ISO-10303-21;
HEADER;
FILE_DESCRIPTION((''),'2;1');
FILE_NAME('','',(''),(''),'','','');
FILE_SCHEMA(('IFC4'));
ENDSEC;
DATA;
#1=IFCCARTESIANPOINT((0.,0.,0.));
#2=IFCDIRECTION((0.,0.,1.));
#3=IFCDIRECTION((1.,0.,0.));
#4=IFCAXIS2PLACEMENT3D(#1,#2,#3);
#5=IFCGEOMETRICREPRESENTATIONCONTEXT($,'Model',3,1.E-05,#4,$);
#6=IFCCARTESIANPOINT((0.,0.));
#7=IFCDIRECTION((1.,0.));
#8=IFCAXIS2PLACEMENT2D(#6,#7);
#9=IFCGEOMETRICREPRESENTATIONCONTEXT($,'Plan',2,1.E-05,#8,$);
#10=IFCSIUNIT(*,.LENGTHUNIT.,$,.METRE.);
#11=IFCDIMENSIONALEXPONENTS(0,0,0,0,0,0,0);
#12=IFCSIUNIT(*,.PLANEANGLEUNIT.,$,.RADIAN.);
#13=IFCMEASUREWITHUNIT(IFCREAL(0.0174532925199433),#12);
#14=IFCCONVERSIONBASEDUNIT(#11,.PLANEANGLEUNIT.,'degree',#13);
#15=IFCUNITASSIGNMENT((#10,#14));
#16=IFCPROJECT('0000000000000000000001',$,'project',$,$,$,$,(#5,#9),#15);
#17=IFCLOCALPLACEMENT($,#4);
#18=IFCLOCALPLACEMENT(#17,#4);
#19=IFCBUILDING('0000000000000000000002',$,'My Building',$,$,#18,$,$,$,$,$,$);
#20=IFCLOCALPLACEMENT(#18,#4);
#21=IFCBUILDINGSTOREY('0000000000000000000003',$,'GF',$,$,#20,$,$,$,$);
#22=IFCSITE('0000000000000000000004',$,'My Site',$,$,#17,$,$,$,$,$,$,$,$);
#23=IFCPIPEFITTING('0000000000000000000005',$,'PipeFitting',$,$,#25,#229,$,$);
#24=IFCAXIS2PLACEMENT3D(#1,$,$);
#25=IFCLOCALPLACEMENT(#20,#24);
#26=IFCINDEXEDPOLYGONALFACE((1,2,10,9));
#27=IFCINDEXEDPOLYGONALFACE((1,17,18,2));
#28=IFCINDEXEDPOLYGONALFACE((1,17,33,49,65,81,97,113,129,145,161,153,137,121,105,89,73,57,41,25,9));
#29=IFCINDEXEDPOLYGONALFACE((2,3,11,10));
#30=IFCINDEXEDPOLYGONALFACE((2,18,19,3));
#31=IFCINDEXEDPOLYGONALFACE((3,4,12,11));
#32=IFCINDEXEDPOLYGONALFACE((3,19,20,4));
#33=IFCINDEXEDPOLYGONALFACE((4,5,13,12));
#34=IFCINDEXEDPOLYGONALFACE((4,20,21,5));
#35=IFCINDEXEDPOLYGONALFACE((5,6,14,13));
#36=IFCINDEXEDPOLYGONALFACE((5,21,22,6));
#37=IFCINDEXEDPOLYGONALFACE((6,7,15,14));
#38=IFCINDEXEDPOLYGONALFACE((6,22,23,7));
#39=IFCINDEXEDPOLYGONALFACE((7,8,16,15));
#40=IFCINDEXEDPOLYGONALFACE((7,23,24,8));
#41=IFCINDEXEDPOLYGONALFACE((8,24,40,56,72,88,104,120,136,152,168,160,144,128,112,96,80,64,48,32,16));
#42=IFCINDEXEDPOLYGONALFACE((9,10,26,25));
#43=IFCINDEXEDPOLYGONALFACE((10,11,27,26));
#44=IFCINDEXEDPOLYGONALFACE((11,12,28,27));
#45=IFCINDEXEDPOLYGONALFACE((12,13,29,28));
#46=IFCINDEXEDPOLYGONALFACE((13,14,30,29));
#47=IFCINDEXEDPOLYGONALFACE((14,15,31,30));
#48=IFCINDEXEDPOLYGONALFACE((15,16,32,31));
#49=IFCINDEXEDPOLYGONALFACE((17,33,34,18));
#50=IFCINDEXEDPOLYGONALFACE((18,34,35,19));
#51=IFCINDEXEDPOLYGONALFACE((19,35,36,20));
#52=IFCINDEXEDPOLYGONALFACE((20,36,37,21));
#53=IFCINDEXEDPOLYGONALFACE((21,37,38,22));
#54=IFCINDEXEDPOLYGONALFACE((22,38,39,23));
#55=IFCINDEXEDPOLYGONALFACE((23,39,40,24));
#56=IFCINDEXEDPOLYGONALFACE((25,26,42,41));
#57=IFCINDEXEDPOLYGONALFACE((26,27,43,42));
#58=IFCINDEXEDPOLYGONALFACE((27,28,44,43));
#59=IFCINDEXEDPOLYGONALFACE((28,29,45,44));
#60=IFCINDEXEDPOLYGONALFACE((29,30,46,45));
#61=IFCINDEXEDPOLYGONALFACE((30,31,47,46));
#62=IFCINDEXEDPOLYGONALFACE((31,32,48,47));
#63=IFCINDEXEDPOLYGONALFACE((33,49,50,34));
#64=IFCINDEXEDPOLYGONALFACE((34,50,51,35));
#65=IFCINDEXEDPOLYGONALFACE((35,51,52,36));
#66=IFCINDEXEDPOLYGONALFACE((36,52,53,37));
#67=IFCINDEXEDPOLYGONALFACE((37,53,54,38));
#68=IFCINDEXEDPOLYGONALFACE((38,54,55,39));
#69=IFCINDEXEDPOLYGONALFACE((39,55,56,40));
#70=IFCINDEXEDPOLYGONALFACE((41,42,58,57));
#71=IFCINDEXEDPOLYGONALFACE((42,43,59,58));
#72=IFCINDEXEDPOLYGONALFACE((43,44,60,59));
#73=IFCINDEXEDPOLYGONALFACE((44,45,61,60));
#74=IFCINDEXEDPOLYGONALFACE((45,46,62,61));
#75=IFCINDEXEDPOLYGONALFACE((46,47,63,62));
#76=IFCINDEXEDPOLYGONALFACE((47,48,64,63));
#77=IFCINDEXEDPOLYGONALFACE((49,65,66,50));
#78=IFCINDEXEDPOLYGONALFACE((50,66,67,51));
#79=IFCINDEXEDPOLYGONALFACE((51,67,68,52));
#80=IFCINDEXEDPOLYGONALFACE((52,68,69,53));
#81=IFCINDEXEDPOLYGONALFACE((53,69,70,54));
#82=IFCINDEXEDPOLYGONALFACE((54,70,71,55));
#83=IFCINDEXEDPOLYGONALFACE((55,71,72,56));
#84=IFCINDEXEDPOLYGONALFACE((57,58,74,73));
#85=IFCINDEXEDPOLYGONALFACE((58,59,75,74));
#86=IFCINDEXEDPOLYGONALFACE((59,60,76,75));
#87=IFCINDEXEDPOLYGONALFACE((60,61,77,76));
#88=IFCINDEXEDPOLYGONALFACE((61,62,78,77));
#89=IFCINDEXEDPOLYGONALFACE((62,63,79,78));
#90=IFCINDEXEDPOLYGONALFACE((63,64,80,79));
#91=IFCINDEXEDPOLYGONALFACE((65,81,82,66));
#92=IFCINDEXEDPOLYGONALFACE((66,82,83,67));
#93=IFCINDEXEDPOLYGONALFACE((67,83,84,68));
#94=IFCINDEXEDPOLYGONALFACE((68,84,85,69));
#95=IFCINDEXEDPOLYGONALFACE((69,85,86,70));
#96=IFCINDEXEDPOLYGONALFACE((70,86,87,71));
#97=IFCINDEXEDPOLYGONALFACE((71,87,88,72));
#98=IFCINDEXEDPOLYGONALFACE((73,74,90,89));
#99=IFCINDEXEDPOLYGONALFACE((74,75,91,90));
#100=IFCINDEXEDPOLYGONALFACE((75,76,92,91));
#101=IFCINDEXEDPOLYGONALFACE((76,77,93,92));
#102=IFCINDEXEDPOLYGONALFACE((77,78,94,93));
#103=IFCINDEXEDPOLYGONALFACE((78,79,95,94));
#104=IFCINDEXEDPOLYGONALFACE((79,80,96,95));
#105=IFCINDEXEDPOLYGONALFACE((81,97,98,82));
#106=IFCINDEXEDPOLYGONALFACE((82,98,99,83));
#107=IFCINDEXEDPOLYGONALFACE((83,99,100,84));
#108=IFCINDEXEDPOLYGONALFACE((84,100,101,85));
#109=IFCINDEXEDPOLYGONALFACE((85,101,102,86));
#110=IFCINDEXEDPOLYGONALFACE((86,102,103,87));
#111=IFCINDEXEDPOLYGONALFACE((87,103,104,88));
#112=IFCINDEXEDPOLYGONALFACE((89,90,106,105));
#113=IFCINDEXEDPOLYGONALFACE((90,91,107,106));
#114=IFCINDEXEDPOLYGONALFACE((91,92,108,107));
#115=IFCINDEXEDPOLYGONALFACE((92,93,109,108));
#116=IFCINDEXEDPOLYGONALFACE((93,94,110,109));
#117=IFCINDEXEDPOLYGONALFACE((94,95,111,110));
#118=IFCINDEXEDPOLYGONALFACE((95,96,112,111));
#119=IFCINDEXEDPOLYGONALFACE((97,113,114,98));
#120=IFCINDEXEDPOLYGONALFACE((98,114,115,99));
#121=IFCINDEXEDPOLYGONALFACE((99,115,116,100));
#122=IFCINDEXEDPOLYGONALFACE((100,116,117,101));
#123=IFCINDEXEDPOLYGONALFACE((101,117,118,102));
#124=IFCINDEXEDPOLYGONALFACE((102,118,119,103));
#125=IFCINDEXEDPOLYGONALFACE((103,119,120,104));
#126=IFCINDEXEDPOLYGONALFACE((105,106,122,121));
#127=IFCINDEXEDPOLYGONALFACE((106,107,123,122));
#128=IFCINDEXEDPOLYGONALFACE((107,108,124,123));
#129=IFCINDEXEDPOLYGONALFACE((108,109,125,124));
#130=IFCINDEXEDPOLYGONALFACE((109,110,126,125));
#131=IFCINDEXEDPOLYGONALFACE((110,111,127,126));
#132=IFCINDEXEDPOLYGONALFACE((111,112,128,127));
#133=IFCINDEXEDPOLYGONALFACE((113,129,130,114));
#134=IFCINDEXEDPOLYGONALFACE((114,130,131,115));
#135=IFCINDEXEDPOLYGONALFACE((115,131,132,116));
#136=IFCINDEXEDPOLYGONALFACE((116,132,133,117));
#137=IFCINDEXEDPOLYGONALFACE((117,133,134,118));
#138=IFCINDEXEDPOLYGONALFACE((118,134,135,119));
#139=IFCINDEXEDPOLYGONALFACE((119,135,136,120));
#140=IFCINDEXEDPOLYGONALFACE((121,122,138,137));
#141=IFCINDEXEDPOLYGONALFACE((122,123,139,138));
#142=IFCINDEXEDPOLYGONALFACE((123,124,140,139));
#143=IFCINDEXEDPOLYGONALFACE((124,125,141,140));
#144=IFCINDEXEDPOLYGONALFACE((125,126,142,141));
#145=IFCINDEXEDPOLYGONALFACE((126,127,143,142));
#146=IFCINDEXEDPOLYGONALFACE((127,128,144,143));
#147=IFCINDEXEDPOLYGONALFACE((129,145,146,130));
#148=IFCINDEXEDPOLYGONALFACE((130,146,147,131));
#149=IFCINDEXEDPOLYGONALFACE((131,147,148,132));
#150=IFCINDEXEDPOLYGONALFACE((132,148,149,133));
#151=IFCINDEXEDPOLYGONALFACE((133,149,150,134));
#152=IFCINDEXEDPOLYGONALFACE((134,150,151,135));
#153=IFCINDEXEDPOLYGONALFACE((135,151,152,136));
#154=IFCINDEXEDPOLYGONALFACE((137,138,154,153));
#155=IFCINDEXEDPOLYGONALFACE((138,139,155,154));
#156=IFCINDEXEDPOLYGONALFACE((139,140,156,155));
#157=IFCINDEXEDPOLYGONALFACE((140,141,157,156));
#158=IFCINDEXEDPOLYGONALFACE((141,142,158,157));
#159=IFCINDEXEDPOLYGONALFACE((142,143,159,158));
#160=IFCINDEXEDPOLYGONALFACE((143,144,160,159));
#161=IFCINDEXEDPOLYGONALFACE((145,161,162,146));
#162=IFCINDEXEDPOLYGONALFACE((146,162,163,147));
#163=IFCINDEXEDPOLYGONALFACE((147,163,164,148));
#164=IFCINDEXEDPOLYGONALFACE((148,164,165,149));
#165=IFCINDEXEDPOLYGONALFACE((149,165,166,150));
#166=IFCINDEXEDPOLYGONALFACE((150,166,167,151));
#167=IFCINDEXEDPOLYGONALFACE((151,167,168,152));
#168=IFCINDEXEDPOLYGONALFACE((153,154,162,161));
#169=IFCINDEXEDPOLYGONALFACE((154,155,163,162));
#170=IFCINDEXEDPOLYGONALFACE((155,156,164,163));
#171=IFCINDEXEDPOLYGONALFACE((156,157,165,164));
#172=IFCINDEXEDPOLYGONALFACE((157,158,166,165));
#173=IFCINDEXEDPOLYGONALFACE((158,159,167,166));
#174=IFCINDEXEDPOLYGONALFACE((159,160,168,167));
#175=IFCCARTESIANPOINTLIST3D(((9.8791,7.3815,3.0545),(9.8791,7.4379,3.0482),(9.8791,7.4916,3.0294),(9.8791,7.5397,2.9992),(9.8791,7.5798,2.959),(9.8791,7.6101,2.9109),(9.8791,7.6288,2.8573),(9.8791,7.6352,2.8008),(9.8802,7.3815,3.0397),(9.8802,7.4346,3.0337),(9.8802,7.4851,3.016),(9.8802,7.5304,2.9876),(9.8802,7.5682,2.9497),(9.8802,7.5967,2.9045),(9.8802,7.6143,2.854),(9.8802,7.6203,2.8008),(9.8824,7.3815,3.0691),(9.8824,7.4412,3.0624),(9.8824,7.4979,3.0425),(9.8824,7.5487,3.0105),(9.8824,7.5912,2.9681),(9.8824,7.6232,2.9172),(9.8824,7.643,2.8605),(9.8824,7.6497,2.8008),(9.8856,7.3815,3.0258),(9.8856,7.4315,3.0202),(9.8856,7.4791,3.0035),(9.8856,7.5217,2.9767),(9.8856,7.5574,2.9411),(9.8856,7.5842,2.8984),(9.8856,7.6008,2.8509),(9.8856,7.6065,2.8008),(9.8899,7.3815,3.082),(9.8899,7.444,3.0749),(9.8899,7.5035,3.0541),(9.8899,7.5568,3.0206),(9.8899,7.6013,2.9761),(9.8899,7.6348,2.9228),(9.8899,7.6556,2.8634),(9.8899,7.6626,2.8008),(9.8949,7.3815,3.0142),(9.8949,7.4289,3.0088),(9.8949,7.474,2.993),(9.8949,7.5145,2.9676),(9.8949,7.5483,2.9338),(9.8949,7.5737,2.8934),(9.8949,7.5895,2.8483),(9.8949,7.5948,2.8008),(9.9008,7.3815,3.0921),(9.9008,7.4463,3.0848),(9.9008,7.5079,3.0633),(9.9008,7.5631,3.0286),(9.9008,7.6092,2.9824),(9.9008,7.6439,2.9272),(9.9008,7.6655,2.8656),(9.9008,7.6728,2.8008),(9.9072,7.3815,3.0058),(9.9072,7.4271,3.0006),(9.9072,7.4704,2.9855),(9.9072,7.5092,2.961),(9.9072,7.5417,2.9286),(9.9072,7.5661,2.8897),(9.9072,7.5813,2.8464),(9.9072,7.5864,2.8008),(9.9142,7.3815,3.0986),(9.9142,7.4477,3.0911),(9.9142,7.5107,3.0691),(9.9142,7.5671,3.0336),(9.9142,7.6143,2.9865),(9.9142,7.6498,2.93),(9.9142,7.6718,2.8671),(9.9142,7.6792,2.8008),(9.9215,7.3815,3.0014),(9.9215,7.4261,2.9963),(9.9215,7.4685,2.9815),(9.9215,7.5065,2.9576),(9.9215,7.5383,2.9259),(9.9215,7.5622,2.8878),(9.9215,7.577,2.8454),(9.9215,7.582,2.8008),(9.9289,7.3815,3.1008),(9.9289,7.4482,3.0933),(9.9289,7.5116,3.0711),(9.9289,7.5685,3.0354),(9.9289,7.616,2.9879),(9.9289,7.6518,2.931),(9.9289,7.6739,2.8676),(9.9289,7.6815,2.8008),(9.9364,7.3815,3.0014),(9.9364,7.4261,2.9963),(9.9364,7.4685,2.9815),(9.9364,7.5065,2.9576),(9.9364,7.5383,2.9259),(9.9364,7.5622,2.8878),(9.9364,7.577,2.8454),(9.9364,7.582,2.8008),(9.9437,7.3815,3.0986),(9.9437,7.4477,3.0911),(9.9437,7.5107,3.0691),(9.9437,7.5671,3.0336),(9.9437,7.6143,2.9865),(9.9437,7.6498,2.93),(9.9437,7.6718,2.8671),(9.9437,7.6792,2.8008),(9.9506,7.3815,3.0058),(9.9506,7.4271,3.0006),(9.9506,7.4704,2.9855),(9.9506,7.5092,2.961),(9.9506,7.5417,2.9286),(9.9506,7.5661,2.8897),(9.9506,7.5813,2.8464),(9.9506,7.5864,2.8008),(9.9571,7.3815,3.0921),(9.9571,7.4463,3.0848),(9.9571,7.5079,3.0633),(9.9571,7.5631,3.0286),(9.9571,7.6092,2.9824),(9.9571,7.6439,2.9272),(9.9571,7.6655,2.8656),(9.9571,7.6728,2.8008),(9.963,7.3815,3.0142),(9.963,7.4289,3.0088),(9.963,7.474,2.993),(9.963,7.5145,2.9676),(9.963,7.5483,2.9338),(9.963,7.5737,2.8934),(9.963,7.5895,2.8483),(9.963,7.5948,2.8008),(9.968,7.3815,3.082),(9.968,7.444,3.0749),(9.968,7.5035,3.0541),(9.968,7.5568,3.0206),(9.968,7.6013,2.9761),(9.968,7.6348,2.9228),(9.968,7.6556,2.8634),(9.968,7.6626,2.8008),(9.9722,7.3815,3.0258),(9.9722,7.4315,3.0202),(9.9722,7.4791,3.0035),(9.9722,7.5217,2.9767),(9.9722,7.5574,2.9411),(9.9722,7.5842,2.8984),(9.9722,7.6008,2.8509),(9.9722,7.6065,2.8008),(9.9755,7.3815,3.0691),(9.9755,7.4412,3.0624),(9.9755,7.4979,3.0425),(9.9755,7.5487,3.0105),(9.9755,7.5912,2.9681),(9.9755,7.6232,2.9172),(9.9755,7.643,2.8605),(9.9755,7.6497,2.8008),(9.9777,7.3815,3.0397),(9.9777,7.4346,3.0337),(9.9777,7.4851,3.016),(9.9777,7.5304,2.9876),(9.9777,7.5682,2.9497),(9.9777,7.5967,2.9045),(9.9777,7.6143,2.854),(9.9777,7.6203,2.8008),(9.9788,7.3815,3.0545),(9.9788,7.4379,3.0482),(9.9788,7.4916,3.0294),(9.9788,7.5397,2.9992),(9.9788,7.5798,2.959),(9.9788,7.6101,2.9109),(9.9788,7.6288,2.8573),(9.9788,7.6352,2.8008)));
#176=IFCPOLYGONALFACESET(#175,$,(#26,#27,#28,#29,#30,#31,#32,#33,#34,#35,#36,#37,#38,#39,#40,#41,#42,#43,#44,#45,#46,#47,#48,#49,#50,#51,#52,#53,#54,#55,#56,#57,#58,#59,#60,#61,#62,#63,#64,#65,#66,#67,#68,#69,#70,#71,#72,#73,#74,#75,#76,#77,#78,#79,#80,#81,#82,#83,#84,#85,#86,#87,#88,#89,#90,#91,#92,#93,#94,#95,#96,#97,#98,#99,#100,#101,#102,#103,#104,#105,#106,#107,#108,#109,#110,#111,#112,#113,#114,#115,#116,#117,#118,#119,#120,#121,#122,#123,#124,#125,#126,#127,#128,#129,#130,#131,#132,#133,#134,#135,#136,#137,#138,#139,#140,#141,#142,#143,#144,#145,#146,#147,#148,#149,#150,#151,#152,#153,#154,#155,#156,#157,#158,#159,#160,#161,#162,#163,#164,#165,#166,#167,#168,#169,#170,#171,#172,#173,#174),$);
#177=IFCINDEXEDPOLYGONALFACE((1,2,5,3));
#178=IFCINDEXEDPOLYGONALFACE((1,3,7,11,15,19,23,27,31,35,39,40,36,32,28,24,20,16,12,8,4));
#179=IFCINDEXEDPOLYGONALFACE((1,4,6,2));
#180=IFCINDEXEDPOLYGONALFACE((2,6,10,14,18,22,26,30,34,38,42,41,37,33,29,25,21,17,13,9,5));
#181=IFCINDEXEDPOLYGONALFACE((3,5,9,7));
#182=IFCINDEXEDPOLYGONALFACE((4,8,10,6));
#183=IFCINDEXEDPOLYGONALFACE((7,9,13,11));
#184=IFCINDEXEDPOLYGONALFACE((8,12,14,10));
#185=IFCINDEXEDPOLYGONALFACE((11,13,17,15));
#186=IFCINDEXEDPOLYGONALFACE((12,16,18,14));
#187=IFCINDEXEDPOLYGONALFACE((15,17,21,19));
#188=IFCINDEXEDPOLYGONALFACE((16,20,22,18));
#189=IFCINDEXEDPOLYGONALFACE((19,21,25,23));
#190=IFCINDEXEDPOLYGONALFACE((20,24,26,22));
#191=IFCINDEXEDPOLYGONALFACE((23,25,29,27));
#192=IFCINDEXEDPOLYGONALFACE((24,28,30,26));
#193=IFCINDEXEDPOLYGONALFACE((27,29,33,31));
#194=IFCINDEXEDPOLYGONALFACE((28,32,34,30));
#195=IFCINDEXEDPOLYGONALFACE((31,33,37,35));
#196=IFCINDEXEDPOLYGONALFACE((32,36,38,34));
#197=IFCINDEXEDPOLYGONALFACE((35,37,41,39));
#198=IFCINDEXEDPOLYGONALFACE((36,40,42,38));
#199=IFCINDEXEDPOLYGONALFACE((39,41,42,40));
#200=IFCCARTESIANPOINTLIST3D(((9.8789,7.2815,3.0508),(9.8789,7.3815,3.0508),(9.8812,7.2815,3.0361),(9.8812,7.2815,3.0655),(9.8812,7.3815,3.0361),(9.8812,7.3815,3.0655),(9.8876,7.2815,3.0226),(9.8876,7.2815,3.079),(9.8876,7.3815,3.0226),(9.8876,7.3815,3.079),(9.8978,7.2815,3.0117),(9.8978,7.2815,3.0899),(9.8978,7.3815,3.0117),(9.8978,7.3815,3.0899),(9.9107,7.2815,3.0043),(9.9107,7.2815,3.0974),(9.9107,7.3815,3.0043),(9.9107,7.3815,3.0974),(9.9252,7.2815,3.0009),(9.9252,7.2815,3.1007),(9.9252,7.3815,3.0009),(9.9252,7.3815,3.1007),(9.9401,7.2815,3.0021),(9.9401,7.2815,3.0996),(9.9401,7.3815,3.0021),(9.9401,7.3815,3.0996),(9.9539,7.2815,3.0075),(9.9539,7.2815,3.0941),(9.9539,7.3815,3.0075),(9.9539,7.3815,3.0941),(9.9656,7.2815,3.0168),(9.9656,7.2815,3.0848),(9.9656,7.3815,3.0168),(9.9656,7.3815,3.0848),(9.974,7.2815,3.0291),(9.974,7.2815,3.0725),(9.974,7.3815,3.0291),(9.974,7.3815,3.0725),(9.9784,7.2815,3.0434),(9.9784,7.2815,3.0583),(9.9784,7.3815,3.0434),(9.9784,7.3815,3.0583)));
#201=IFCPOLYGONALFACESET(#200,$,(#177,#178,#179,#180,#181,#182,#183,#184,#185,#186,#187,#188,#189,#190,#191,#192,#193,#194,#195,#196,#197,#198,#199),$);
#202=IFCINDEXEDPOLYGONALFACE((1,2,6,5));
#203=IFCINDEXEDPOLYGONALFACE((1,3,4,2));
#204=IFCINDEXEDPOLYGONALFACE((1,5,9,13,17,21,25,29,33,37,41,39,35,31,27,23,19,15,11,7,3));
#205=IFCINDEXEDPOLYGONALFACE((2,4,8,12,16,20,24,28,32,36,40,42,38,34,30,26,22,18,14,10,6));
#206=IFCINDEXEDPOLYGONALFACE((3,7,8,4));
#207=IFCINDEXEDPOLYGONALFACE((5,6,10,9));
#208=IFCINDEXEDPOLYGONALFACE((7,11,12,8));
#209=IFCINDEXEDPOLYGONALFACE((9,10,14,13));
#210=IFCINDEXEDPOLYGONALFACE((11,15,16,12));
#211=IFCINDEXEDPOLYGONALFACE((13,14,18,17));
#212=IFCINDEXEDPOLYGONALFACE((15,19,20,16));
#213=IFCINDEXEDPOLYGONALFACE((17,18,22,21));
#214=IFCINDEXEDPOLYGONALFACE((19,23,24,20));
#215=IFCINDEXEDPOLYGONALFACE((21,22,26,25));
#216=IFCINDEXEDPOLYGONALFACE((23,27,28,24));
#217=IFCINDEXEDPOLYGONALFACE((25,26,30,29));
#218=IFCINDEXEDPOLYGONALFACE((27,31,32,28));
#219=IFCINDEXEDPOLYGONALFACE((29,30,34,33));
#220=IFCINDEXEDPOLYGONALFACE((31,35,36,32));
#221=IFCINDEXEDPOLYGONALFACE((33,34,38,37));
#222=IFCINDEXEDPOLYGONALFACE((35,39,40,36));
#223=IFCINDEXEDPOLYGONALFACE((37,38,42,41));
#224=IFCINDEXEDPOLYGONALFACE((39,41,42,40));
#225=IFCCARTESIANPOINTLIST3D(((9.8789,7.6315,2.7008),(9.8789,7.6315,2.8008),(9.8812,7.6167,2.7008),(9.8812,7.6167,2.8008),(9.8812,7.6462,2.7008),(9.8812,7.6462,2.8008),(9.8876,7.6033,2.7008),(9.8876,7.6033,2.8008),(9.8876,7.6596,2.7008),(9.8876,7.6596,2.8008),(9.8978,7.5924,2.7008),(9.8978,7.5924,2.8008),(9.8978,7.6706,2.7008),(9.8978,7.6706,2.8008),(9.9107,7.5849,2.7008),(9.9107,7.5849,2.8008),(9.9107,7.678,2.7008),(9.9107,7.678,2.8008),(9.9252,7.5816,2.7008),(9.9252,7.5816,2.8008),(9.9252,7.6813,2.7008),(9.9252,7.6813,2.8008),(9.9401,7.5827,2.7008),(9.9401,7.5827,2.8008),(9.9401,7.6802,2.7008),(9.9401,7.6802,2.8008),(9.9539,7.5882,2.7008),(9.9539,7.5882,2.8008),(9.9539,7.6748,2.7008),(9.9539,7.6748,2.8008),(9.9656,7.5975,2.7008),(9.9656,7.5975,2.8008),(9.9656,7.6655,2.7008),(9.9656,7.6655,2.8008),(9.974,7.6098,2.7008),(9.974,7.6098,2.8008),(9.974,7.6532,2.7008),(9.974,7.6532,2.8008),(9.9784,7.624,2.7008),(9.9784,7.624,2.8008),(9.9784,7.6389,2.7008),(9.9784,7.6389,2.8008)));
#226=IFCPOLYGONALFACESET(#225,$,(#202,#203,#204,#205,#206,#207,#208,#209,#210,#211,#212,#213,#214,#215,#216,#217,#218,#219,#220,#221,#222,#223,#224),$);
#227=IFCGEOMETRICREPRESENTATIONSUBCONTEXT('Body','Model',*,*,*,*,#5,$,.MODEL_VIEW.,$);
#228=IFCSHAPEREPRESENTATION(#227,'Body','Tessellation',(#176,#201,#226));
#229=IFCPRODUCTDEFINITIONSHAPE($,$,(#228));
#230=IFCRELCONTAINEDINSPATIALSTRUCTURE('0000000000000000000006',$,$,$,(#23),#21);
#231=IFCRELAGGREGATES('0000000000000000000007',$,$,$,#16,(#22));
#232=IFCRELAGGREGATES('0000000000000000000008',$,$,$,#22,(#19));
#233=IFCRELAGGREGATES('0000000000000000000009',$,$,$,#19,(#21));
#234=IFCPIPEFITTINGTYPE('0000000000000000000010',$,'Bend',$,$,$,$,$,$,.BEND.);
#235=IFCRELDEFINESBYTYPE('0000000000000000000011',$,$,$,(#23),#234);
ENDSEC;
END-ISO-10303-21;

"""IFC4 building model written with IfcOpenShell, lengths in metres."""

from ifc_helpers import new_model, entity, si_unit, converted_unit, frame, origin_with_axes, origin_2d_with_axis, place, context, subcontext, project, spatial, circle, extrude, source, transform, mapped, type_object, type_shapes, element, save


model = new_model("IFC4")

# Units and contexts
model_context = context("Model", 3, precision=1e-05, world=origin_with_axes())
plan_context = context("Plan", 2, precision=1e-05, world=origin_2d_with_axis())
body_context_1 = subcontext(model_context, "Body", "Model", "MODEL_VIEW")
ifc_project = project(units=[si_unit("LENGTHUNIT", "METRE"), converted_unit("PLANEANGLEUNIT", "degree", entity("IfcReal", 0.0174532925199433), si_unit("PLANEANGLEUNIT", "RADIAN"), dimensions=[0, 0, 0, 0, 0, 0, 0])], contexts=[model_context, plan_context])

# Site, building, storey
site_placement = place(None, origin_with_axes())
site = spatial("IfcSite", under=ifc_project, at=site_placement, Name="My Site")
building_placement = place(site_placement, origin_with_axes())
building = spatial("IfcBuilding", under=site, at=building_placement, Name="My Building")
storey_placement = place(building_placement, origin_with_axes())
storey = spatial("IfcBuildingStorey", under=building, at=storey_placement, Name="GF")

# Pipe fitting
pipe_fitting_type = type_object("IfcPipeFittingType", Name="Bend", PredefinedType="BEND")
shared_shape_1 = source(origin_with_axes(), body_context_1, "Body", "SolidModel", [
    entity("IfcSweptDiskSolid", entity("IfcIndexedPolyCurve", entity("IfcCartesianPointList3D", [[0.0, 0.0, 0.1], [0.0, -0.0732, 0.2768], [0.0, -0.25, 0.35]]), [entity("IfcArcIndex", [1, 2, 3])]), 0.05),
    extrude(circle(Radius=0.05), origin_with_axes(), (0.0, 0.0, 1.0), 0.1),
    extrude(circle(Radius=0.05), frame((0.0, -0.25, 0.35), z_axis=(0.0, -1.0, 0.0), x_axis=(1.0, 0.0, 0.0)), (0.0, 0.0, 1.0), 0.1),
])
type_shapes(pipe_fitting_type, [shared_shape_1])
for number, where, z_axis, x_axis, name in (
    (1, (9.9289, 7.2815, 3.0508), (0.0, 1.0, 0.0), (-1.0, 0.0, 0.0), "PipeFitting"),
):
    element("IfcPipeFitting", number, at=place(storey_placement, frame(where, z_axis=z_axis, x_axis=x_axis)), inside=storey, type_object=pipe_fitting_type, Name=name, context=body_context_1, shape_type="MappedRepresentation", body=[
        mapped(shared_shape_1, transform((0.0, 0.0, 0.0), x_axis=(1.0, 0.0, 0.0), y_axis=(0.0, 1.0, 0.0), z_axis=(0.0, 0.0, 1.0), scale=1.0)),
    ])

save(model, "model.ifc")
